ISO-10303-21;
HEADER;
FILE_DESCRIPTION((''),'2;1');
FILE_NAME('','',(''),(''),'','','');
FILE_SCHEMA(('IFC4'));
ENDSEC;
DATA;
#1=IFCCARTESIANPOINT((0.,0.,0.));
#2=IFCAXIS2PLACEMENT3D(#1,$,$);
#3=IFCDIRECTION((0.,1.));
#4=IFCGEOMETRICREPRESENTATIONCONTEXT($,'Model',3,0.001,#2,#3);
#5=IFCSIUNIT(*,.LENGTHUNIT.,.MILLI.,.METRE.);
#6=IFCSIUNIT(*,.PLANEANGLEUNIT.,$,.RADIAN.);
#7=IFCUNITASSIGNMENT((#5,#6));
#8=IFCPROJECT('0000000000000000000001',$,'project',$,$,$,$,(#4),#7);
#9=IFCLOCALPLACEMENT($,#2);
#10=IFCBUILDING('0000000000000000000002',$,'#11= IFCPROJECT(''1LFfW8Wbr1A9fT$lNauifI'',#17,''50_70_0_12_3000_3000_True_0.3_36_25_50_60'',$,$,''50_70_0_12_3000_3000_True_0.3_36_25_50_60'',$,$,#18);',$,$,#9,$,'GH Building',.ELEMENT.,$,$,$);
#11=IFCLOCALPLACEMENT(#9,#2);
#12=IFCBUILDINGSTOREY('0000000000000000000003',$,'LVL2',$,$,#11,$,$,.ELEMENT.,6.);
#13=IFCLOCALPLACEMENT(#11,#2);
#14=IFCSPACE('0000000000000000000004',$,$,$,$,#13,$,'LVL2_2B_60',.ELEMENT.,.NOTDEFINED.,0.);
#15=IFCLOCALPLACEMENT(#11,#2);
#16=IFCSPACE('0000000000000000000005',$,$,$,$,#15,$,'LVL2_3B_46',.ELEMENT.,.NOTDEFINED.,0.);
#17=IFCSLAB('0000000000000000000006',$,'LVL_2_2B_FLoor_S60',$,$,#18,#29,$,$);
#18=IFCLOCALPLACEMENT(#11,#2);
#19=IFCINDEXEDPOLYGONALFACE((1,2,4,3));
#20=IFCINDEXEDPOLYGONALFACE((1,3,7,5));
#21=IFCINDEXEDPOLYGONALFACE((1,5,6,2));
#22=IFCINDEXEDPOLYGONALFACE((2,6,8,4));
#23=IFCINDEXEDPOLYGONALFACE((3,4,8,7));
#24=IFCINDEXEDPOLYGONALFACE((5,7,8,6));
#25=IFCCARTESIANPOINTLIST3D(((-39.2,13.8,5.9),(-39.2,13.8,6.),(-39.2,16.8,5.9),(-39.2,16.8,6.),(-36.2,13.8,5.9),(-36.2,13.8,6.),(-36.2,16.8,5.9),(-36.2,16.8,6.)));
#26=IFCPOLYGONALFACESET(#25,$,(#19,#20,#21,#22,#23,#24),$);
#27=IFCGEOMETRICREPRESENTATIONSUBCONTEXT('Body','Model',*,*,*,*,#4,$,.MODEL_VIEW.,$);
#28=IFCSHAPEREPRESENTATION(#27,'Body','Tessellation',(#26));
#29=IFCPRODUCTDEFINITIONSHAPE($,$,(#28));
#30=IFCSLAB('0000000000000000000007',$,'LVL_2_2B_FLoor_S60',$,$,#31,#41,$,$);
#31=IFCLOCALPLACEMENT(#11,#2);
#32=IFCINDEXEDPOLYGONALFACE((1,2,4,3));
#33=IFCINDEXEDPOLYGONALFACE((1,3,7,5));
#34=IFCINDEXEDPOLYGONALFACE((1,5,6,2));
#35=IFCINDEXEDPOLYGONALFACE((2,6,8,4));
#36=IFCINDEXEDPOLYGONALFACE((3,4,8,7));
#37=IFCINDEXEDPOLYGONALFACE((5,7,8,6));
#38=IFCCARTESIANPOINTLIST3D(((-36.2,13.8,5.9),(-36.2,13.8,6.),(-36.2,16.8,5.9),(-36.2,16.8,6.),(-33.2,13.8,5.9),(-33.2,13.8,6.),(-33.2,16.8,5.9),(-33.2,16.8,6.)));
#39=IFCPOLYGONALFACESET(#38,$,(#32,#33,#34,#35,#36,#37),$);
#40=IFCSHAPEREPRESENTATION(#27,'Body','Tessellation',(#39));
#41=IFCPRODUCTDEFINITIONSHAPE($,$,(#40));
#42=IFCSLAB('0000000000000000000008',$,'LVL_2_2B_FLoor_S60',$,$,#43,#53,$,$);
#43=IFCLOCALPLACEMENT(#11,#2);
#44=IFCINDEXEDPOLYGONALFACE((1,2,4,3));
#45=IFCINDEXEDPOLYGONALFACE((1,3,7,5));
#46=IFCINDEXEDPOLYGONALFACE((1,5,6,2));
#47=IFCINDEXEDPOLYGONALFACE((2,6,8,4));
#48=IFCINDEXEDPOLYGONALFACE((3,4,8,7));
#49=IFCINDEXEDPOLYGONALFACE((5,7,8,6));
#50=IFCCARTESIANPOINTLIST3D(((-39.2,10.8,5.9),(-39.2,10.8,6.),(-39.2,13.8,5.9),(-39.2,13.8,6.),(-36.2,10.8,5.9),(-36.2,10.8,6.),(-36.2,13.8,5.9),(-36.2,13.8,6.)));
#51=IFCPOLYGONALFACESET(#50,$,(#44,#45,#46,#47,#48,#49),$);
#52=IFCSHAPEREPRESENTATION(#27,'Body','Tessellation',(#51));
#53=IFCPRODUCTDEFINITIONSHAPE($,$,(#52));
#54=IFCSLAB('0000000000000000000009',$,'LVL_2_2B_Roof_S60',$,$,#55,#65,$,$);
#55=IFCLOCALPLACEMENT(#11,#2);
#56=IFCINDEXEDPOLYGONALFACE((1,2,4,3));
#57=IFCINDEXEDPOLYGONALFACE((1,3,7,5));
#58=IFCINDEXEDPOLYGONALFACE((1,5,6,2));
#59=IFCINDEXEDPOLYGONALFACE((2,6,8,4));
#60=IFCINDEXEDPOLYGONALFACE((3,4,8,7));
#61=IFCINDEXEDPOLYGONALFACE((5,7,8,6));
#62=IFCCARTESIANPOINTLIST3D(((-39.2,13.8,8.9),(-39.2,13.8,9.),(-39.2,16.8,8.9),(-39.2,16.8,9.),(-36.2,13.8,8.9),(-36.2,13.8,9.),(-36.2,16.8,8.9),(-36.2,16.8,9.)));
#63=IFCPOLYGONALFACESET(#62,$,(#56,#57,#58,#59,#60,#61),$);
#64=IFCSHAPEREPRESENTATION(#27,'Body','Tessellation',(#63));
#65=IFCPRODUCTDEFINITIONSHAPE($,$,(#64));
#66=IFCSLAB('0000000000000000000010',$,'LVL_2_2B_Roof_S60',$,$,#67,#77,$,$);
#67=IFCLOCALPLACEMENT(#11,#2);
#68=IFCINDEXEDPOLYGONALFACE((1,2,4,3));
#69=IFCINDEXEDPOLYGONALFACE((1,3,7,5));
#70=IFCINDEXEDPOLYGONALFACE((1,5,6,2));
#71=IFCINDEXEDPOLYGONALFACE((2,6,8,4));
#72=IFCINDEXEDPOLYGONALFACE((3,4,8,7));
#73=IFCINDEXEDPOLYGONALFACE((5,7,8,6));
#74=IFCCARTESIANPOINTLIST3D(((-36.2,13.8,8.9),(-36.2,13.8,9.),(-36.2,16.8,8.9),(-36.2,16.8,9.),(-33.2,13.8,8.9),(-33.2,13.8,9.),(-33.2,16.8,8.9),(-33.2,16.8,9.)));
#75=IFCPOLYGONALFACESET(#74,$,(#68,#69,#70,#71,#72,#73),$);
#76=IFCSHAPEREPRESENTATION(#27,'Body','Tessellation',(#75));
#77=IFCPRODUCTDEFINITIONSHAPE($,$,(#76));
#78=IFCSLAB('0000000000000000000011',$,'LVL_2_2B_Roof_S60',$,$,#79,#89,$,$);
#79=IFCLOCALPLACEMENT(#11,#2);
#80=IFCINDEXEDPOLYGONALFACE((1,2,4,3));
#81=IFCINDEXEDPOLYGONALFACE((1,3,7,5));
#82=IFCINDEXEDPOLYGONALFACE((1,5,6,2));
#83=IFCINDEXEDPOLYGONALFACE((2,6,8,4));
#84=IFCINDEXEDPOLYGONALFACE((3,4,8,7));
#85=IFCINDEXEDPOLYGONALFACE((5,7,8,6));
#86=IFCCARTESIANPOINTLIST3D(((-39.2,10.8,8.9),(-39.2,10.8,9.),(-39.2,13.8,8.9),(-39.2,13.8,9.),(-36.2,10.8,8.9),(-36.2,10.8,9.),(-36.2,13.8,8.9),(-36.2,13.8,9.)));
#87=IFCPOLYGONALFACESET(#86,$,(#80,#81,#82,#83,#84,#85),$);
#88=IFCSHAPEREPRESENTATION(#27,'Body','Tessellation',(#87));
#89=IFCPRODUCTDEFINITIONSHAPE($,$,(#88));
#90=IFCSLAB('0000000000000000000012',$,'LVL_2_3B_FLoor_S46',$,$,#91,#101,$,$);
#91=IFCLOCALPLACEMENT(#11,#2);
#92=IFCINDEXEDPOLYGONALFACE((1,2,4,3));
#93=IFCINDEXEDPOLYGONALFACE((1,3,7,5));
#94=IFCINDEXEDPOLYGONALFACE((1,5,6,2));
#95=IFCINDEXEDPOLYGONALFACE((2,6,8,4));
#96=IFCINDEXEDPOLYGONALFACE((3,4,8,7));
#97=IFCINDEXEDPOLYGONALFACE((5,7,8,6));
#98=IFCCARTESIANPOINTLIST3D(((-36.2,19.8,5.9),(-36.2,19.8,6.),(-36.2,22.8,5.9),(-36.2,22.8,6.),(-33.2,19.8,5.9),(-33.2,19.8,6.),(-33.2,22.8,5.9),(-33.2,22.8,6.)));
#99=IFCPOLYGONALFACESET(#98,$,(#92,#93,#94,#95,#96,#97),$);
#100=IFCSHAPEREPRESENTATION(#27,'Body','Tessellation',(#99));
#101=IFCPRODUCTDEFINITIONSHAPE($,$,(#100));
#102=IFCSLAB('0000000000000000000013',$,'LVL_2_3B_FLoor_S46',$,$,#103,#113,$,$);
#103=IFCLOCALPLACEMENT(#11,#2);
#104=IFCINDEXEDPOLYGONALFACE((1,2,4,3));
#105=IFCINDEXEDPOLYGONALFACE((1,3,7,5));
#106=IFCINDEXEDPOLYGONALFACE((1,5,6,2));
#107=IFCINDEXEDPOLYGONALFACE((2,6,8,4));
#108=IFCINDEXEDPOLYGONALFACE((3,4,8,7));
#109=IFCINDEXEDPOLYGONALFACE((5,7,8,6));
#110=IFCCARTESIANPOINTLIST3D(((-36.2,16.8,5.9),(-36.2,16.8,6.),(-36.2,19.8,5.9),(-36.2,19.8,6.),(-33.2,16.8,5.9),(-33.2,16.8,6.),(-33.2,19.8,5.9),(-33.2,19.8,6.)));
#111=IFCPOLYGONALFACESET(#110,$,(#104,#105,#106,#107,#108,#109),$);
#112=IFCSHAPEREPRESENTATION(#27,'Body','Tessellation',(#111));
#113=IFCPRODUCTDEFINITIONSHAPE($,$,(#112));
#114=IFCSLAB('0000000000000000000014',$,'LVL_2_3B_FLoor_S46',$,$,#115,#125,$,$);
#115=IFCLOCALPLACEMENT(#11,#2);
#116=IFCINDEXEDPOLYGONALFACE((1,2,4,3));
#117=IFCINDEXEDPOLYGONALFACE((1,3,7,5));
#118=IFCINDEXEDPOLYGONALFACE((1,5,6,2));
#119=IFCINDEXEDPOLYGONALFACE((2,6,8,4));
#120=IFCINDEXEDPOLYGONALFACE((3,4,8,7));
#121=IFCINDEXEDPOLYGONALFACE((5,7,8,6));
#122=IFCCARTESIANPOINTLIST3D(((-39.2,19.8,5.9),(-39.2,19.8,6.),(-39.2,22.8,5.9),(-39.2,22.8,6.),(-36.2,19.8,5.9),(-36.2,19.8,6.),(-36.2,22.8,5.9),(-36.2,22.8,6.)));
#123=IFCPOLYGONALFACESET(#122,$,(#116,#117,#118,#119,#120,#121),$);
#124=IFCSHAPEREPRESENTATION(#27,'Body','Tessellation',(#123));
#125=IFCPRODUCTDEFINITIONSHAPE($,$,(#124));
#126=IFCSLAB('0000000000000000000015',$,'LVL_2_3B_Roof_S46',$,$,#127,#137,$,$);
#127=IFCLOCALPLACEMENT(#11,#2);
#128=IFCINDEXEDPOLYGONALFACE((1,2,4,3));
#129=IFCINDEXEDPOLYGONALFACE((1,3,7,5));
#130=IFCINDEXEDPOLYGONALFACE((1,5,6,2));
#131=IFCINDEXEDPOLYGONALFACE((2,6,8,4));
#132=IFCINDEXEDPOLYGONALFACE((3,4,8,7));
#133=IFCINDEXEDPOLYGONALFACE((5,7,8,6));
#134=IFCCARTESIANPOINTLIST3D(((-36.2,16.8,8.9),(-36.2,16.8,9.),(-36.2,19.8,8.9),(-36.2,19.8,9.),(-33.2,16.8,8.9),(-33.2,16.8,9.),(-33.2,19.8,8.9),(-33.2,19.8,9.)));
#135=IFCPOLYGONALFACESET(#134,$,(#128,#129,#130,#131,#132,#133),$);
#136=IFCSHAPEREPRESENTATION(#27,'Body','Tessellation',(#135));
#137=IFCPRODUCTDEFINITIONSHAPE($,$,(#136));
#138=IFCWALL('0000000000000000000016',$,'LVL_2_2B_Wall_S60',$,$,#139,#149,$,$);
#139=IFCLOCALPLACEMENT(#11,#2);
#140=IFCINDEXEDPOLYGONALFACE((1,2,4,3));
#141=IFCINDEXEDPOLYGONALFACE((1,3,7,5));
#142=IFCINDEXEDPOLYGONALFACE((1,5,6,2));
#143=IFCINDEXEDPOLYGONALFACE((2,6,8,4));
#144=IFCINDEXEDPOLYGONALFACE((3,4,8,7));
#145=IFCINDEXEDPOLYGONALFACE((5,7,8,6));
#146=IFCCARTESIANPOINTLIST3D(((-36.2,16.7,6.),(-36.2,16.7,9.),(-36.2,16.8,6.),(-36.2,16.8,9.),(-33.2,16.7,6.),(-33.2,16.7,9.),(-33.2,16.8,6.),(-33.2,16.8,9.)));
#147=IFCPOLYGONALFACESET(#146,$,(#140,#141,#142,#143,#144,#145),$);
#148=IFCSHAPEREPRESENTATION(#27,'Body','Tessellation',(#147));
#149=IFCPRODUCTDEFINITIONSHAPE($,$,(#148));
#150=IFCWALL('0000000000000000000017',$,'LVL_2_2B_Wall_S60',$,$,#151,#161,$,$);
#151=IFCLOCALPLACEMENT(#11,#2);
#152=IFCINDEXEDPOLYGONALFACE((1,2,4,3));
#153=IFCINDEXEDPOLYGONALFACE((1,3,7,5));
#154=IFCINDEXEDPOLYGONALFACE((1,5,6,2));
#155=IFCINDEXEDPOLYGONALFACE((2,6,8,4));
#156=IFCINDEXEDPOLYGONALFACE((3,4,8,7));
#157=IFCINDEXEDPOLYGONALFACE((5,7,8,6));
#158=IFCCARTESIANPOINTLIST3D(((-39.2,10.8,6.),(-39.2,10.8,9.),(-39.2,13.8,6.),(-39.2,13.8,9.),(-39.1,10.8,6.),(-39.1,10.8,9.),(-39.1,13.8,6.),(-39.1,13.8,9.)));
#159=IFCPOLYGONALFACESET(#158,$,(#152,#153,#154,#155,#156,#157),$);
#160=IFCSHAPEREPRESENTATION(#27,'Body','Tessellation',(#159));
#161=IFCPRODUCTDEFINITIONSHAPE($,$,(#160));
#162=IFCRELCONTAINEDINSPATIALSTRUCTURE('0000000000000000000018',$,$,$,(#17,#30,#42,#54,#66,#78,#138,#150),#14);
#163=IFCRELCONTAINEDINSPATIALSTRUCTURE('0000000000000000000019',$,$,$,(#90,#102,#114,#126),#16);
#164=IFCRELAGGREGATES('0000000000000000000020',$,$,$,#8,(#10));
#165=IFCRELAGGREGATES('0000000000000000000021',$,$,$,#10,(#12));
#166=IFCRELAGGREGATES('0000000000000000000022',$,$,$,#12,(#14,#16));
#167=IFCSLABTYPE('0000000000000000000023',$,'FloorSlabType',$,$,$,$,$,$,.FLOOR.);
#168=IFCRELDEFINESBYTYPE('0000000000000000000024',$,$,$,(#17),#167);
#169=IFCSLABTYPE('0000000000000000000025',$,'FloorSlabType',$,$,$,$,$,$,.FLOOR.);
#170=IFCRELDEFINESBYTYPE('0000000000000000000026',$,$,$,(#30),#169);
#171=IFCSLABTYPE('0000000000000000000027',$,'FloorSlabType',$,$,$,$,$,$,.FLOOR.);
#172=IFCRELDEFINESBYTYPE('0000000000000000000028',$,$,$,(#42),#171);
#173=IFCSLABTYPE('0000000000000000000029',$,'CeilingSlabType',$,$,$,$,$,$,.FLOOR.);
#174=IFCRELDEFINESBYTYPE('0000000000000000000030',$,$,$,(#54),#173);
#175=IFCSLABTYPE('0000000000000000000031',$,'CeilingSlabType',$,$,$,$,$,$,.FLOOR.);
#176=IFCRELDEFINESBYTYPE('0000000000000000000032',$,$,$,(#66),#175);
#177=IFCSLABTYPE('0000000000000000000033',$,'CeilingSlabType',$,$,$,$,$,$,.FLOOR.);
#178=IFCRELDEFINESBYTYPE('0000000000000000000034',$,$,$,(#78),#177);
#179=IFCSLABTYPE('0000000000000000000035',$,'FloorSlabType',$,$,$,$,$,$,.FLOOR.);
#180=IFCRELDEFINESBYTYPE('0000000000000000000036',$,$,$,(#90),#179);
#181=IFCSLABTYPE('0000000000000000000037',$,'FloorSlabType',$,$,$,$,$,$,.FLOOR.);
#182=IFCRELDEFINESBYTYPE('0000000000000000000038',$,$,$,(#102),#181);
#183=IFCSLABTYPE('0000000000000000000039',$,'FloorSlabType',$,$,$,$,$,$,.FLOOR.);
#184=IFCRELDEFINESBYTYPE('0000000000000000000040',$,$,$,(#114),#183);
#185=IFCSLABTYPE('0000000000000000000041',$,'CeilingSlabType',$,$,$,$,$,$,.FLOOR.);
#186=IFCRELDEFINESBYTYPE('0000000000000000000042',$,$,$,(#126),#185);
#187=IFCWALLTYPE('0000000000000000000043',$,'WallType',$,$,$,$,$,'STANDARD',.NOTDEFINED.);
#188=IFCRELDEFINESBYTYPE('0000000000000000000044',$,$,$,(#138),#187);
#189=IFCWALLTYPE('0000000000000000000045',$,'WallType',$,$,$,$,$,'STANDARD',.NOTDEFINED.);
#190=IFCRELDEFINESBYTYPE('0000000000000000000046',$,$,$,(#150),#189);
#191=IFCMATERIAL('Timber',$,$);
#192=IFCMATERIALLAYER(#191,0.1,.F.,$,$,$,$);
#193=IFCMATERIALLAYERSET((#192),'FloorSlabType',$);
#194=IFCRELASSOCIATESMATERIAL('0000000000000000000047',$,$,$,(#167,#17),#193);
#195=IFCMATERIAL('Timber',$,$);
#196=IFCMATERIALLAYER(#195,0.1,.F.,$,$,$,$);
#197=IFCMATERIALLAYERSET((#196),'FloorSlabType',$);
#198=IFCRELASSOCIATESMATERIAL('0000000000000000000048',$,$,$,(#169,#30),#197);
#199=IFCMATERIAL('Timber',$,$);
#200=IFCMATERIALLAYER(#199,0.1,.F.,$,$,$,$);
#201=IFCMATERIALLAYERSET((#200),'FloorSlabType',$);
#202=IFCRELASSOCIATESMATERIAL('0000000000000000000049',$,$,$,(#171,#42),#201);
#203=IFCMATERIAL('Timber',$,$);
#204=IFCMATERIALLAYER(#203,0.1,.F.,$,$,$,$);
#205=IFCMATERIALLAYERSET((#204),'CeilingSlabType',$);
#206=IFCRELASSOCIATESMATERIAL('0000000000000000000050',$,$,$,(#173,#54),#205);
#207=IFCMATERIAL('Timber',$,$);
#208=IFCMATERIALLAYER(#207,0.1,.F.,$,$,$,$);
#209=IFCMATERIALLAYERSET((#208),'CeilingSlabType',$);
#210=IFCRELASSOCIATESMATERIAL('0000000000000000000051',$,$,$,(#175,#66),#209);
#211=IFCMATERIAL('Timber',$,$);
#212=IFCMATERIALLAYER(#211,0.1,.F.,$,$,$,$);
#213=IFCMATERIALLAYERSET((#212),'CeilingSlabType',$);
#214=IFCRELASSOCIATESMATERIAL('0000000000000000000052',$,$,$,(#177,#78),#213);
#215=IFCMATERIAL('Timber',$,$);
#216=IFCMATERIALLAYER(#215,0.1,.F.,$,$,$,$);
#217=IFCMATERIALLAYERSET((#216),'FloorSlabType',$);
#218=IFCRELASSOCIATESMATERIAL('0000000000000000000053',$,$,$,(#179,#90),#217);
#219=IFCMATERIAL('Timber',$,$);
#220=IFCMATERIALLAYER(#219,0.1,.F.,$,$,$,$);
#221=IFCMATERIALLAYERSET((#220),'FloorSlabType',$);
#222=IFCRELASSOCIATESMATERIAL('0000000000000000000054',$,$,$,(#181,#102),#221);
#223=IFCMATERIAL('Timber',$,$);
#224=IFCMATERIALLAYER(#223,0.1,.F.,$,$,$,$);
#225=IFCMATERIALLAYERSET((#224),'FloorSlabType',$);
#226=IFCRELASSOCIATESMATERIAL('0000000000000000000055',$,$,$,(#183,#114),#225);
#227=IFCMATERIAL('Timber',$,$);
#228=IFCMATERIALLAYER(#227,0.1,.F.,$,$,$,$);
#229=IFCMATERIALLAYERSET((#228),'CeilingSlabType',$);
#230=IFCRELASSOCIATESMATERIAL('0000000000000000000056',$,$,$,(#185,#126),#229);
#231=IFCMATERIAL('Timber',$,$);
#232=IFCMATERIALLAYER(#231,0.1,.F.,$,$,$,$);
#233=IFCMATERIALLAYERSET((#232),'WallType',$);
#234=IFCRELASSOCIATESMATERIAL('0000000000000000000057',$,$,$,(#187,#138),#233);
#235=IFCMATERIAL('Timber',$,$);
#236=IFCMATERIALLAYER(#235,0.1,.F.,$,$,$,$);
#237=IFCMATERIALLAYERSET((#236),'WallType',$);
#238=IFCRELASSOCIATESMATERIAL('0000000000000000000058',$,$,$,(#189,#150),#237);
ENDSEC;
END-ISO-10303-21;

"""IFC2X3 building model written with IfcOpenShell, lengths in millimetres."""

from ifc_helpers import new_model, si_unit, direction, frame, frame_2d, origin, place, context, subcontext, project, spatial, rectangle, extrude, material, layer, layer_set, layer_usage, type_object, element, save


model = new_model("IFC2X3")

# Units and contexts
model_context = context("Model", 3, precision=0.001, world=origin(), true_north=direction((0.0, 1.0)))
body_context = subcontext(model_context, "Body", "Model", "MODEL_VIEW")
ifc_project = project(units=[si_unit("LENGTHUNIT", "METRE", prefix="MILLI"), si_unit("PLANEANGLEUNIT", "RADIAN")], contexts=[model_context])

# Building, storey
building_placement = place(None, origin())
building = spatial("IfcBuilding", under=ifc_project, at=building_placement, Name="#11= IFCPROJECT('1LFfW8Wbr1A9fT$lNauifI',#17,'50_70_0_12_3000_3000_True_0.3_36_25_50_60',$,$,'50_70_0_12_3000_3000_True_0.3_36_25_50_60',$,$,#18);", LongName="GH Building", CompositionType="ELEMENT")
storey_placement = place(building_placement, origin())
storey = spatial("IfcBuildingStorey", under=building, at=storey_placement, Name="LVL2", CompositionType="ELEMENT", Elevation=6.0)

# Shared definitions
space_1_placement = place(storey_placement, origin())
space_1 = spatial("IfcSpace", under=storey, at=space_1_placement, LongName="LVL2_2B_60", CompositionType="ELEMENT", InteriorOrExteriorSpace="NOTDEFINED", ElevationWithFlooring=0.0)

# Slabs
ifc_material_1 = material(Name="Timber")
ifc_layer_1 = layer(ifc_material_1, 0.1, ventilated=False)
ifc_layer_set_1 = layer_set([ifc_layer_1], Name="FloorSlabType")
ifc_layer_usage_1 = layer_usage(ifc_layer_set_1, "AXIS3", "NEGATIVE", -0.1)
slab_type_1 = type_object("IfcSlabType", Name="FloorSlabType", PredefinedType="FLOOR", material=ifc_layer_set_1)
slab_1_placement = place(space_1_placement, frame((-39.2, 13.8, 5.9)))
element("IfcSlab", 1, at=slab_1_placement, inside=space_1, type_object=slab_type_1, material=ifc_layer_usage_1, Name="LVL_2_2B_FLoor_S60", context=body_context, shape_type="SweptSolid", body=[
    extrude(rectangle(XDim=3.0, YDim=3.0, at=frame_2d((1.5, 1.5))), origin(), (0.0, 0.0, 1.0), 0.1),
])
ifc_material_2 = material(Name="Timber")
ifc_layer_2 = layer(ifc_material_2, 0.1, ventilated=False)
ifc_layer_set_2 = layer_set([ifc_layer_2], Name="FloorSlabType")
ifc_layer_usage_2 = layer_usage(ifc_layer_set_2, "AXIS3", "NEGATIVE", -0.1)
slab_type_2 = type_object("IfcSlabType", Name="FloorSlabType", PredefinedType="FLOOR", material=ifc_layer_set_2)
slab_2_placement = place(space_1_placement, frame((-36.2, 13.8, 5.9)))
element("IfcSlab", 2, at=slab_2_placement, inside=space_1, type_object=slab_type_2, material=ifc_layer_usage_2, Name="LVL_2_2B_FLoor_S60", context=body_context, shape_type="SweptSolid", body=[
    extrude(rectangle(XDim=3.0, YDim=3.0, at=frame_2d((1.5, 1.5))), origin(), (0.0, 0.0, 1.0), 0.1),
])
ifc_material_3 = material(Name="Timber")
ifc_layer_3 = layer(ifc_material_3, 0.1, ventilated=False)
ifc_layer_set_3 = layer_set([ifc_layer_3], Name="FloorSlabType")
ifc_layer_usage_3 = layer_usage(ifc_layer_set_3, "AXIS3", "NEGATIVE", -0.1)
slab_type_3 = type_object("IfcSlabType", Name="FloorSlabType", PredefinedType="FLOOR", material=ifc_layer_set_3)
slab_3_placement = place(space_1_placement, frame((-39.2, 10.8, 5.9)))
element("IfcSlab", 3, at=slab_3_placement, inside=space_1, type_object=slab_type_3, material=ifc_layer_usage_3, Name="LVL_2_2B_FLoor_S60", context=body_context, shape_type="SweptSolid", body=[
    extrude(rectangle(XDim=3.0, YDim=3.0, at=frame_2d((1.5, 1.5))), origin(), (0.0, 0.0, 1.0), 0.1),
])
ifc_material_4 = material(Name="Timber")
ifc_layer_4 = layer(ifc_material_4, 0.1, ventilated=False)
ifc_layer_set_4 = layer_set([ifc_layer_4], Name="CeilingSlabType")
ifc_layer_usage_4 = layer_usage(ifc_layer_set_4, "AXIS3", "NEGATIVE", -0.1)
slab_type_4 = type_object("IfcSlabType", Name="CeilingSlabType", PredefinedType="FLOOR", material=ifc_layer_set_4)
slab_4_placement = place(space_1_placement, frame((-39.2, 13.8, 8.9)))
element("IfcSlab", 4, at=slab_4_placement, inside=space_1, type_object=slab_type_4, material=ifc_layer_usage_4, Name="LVL_2_2B_Roof_S60", context=body_context, shape_type="SweptSolid", body=[
    extrude(rectangle(XDim=3.0, YDim=3.0, at=frame_2d((1.5, 1.5))), origin(), (0.0, 0.0, 1.0), 0.1),
])
ifc_material_5 = material(Name="Timber")
ifc_layer_5 = layer(ifc_material_5, 0.1, ventilated=False)
ifc_layer_set_5 = layer_set([ifc_layer_5], Name="CeilingSlabType")
ifc_layer_usage_5 = layer_usage(ifc_layer_set_5, "AXIS3", "NEGATIVE", -0.1)
slab_type_5 = type_object("IfcSlabType", Name="CeilingSlabType", PredefinedType="FLOOR", material=ifc_layer_set_5)
slab_5_placement = place(space_1_placement, frame((-36.2, 13.8, 8.9)))
element("IfcSlab", 5, at=slab_5_placement, inside=space_1, type_object=slab_type_5, material=ifc_layer_usage_5, Name="LVL_2_2B_Roof_S60", context=body_context, shape_type="SweptSolid", body=[
    extrude(rectangle(XDim=3.0, YDim=3.0, at=frame_2d((1.5, 1.5))), origin(), (0.0, 0.0, 1.0), 0.1),
])
ifc_material_6 = material(Name="Timber")
ifc_layer_6 = layer(ifc_material_6, 0.1, ventilated=False)
ifc_layer_set_6 = layer_set([ifc_layer_6], Name="CeilingSlabType")
ifc_layer_usage_6 = layer_usage(ifc_layer_set_6, "AXIS3", "NEGATIVE", -0.1)
slab_type_6 = type_object("IfcSlabType", Name="CeilingSlabType", PredefinedType="FLOOR", material=ifc_layer_set_6)
slab_6_placement = place(space_1_placement, frame((-39.2, 10.8, 8.9)))
element("IfcSlab", 6, at=slab_6_placement, inside=space_1, type_object=slab_type_6, material=ifc_layer_usage_6, Name="LVL_2_2B_Roof_S60", context=body_context, shape_type="SweptSolid", body=[
    extrude(rectangle(XDim=3.0, YDim=3.0, at=frame_2d((1.5, 1.5))), origin(), (0.0, 0.0, 1.0), 0.1),
])

# Shared definitions
space_2_placement = place(storey_placement, origin())
space_2 = spatial("IfcSpace", under=storey, at=space_2_placement, LongName="LVL2_3B_46", CompositionType="ELEMENT", InteriorOrExteriorSpace="NOTDEFINED", ElevationWithFlooring=0.0)

# Slabs
ifc_material_7 = material(Name="Timber")
ifc_layer_7 = layer(ifc_material_7, 0.1, ventilated=False)
ifc_layer_set_7 = layer_set([ifc_layer_7], Name="FloorSlabType")
ifc_layer_usage_7 = layer_usage(ifc_layer_set_7, "AXIS3", "NEGATIVE", -0.1)
slab_type_7 = type_object("IfcSlabType", Name="FloorSlabType", PredefinedType="FLOOR", material=ifc_layer_set_7)
slab_7_placement = place(space_2_placement, frame((-36.2, 19.8, 5.9)))
element("IfcSlab", 7, at=slab_7_placement, inside=space_2, type_object=slab_type_7, material=ifc_layer_usage_7, Name="LVL_2_3B_FLoor_S46", context=body_context, shape_type="SweptSolid", body=[
    extrude(rectangle(XDim=3.0, YDim=3.0, at=frame_2d((1.5, 1.5))), origin(), (0.0, 0.0, 1.0), 0.1),
])
ifc_material_8 = material(Name="Timber")
ifc_layer_8 = layer(ifc_material_8, 0.1, ventilated=False)
ifc_layer_set_8 = layer_set([ifc_layer_8], Name="FloorSlabType")
ifc_layer_usage_8 = layer_usage(ifc_layer_set_8, "AXIS3", "NEGATIVE", -0.1)
slab_type_8 = type_object("IfcSlabType", Name="FloorSlabType", PredefinedType="FLOOR", material=ifc_layer_set_8)
slab_8_placement = place(space_2_placement, frame((-36.2, 16.8, 5.9)))
element("IfcSlab", 8, at=slab_8_placement, inside=space_2, type_object=slab_type_8, material=ifc_layer_usage_8, Name="LVL_2_3B_FLoor_S46", context=body_context, shape_type="SweptSolid", body=[
    extrude(rectangle(XDim=3.0, YDim=3.0, at=frame_2d((1.5, 1.5))), origin(), (0.0, 0.0, 1.0), 0.1),
])
ifc_material_9 = material(Name="Timber")
ifc_layer_9 = layer(ifc_material_9, 0.1, ventilated=False)
ifc_layer_set_9 = layer_set([ifc_layer_9], Name="FloorSlabType")
ifc_layer_usage_9 = layer_usage(ifc_layer_set_9, "AXIS3", "NEGATIVE", -0.1)
slab_type_9 = type_object("IfcSlabType", Name="FloorSlabType", PredefinedType="FLOOR", material=ifc_layer_set_9)
slab_9_placement = place(space_2_placement, frame((-39.2, 19.8, 5.9)))
element("IfcSlab", 9, at=slab_9_placement, inside=space_2, type_object=slab_type_9, material=ifc_layer_usage_9, Name="LVL_2_3B_FLoor_S46", context=body_context, shape_type="SweptSolid", body=[
    extrude(rectangle(XDim=3.0, YDim=3.0, at=frame_2d((1.5, 1.5))), origin(), (0.0, 0.0, 1.0), 0.1),
])
ifc_material_10 = material(Name="Timber")
ifc_layer_10 = layer(ifc_material_10, 0.1, ventilated=False)
ifc_layer_set_10 = layer_set([ifc_layer_10], Name="CeilingSlabType")
ifc_layer_usage_10 = layer_usage(ifc_layer_set_10, "AXIS3", "NEGATIVE", -0.1)
slab_type_10 = type_object("IfcSlabType", Name="CeilingSlabType", PredefinedType="FLOOR", material=ifc_layer_set_10)
slab_10_placement = place(space_2_placement, frame((-36.2, 16.8, 8.9)))
element("IfcSlab", 10, at=slab_10_placement, inside=space_2, type_object=slab_type_10, material=ifc_layer_usage_10, Name="LVL_2_3B_Roof_S46", context=body_context, shape_type="SweptSolid", body=[
    extrude(rectangle(XDim=3.0, YDim=3.0, at=frame_2d((1.5, 1.5))), origin(), (0.0, 0.0, 1.0), 0.1),
])

# Walls
ifc_material_11 = material(Name="Timber")
ifc_layer_11 = layer(ifc_material_11, 0.1, ventilated=False)
ifc_layer_set_11 = layer_set([ifc_layer_11], Name="WallType")
ifc_layer_usage_11 = layer_usage(ifc_layer_set_11, "AXIS2", "NEGATIVE", 0.0)
wall_type_1 = type_object("IfcWallType", Name="WallType", ElementType="STANDARD", PredefinedType="NOTDEFINED", material=ifc_layer_set_11)
wall_1_placement = place(space_1_placement, frame((-36.2, 16.8, 6.0)))
element("IfcWall", 11, at=wall_1_placement, inside=space_1, type_object=wall_type_1, material=ifc_layer_usage_11, Name="LVL_2_2B_Wall_S60", context=body_context, shape_type="SweptSolid", body=[
    extrude(rectangle(XDim=3.0, YDim=0.1, at=frame_2d((1.5, -0.1))), origin(), (0.0, 0.0, 1.0), 3.0),
])
ifc_material_12 = material(Name="Timber")
ifc_layer_12 = layer(ifc_material_12, 0.1, ventilated=False)
ifc_layer_set_12 = layer_set([ifc_layer_12], Name="WallType")
ifc_layer_usage_12 = layer_usage(ifc_layer_set_12, "AXIS2", "NEGATIVE", 0.0)
wall_type_2 = type_object("IfcWallType", Name="WallType", ElementType="STANDARD", PredefinedType="NOTDEFINED", material=ifc_layer_set_12)
wall_2_placement = place(space_1_placement, frame((-39.2, 10.8, 6.0), z_axis=(0.0, 0.0, 1.0), x_axis=(0.0, 1.0, 0.0)))
element("IfcWall", 12, at=wall_2_placement, inside=space_1, type_object=wall_type_2, material=ifc_layer_usage_12, Name="LVL_2_2B_Wall_S60", context=body_context, shape_type="SweptSolid", body=[
    extrude(rectangle(XDim=3.0, YDim=0.1, at=frame_2d((1.5, -0.1))), origin(), (0.0, 0.0, 1.0), 3.0),
])

save(model, "model.ifc")
